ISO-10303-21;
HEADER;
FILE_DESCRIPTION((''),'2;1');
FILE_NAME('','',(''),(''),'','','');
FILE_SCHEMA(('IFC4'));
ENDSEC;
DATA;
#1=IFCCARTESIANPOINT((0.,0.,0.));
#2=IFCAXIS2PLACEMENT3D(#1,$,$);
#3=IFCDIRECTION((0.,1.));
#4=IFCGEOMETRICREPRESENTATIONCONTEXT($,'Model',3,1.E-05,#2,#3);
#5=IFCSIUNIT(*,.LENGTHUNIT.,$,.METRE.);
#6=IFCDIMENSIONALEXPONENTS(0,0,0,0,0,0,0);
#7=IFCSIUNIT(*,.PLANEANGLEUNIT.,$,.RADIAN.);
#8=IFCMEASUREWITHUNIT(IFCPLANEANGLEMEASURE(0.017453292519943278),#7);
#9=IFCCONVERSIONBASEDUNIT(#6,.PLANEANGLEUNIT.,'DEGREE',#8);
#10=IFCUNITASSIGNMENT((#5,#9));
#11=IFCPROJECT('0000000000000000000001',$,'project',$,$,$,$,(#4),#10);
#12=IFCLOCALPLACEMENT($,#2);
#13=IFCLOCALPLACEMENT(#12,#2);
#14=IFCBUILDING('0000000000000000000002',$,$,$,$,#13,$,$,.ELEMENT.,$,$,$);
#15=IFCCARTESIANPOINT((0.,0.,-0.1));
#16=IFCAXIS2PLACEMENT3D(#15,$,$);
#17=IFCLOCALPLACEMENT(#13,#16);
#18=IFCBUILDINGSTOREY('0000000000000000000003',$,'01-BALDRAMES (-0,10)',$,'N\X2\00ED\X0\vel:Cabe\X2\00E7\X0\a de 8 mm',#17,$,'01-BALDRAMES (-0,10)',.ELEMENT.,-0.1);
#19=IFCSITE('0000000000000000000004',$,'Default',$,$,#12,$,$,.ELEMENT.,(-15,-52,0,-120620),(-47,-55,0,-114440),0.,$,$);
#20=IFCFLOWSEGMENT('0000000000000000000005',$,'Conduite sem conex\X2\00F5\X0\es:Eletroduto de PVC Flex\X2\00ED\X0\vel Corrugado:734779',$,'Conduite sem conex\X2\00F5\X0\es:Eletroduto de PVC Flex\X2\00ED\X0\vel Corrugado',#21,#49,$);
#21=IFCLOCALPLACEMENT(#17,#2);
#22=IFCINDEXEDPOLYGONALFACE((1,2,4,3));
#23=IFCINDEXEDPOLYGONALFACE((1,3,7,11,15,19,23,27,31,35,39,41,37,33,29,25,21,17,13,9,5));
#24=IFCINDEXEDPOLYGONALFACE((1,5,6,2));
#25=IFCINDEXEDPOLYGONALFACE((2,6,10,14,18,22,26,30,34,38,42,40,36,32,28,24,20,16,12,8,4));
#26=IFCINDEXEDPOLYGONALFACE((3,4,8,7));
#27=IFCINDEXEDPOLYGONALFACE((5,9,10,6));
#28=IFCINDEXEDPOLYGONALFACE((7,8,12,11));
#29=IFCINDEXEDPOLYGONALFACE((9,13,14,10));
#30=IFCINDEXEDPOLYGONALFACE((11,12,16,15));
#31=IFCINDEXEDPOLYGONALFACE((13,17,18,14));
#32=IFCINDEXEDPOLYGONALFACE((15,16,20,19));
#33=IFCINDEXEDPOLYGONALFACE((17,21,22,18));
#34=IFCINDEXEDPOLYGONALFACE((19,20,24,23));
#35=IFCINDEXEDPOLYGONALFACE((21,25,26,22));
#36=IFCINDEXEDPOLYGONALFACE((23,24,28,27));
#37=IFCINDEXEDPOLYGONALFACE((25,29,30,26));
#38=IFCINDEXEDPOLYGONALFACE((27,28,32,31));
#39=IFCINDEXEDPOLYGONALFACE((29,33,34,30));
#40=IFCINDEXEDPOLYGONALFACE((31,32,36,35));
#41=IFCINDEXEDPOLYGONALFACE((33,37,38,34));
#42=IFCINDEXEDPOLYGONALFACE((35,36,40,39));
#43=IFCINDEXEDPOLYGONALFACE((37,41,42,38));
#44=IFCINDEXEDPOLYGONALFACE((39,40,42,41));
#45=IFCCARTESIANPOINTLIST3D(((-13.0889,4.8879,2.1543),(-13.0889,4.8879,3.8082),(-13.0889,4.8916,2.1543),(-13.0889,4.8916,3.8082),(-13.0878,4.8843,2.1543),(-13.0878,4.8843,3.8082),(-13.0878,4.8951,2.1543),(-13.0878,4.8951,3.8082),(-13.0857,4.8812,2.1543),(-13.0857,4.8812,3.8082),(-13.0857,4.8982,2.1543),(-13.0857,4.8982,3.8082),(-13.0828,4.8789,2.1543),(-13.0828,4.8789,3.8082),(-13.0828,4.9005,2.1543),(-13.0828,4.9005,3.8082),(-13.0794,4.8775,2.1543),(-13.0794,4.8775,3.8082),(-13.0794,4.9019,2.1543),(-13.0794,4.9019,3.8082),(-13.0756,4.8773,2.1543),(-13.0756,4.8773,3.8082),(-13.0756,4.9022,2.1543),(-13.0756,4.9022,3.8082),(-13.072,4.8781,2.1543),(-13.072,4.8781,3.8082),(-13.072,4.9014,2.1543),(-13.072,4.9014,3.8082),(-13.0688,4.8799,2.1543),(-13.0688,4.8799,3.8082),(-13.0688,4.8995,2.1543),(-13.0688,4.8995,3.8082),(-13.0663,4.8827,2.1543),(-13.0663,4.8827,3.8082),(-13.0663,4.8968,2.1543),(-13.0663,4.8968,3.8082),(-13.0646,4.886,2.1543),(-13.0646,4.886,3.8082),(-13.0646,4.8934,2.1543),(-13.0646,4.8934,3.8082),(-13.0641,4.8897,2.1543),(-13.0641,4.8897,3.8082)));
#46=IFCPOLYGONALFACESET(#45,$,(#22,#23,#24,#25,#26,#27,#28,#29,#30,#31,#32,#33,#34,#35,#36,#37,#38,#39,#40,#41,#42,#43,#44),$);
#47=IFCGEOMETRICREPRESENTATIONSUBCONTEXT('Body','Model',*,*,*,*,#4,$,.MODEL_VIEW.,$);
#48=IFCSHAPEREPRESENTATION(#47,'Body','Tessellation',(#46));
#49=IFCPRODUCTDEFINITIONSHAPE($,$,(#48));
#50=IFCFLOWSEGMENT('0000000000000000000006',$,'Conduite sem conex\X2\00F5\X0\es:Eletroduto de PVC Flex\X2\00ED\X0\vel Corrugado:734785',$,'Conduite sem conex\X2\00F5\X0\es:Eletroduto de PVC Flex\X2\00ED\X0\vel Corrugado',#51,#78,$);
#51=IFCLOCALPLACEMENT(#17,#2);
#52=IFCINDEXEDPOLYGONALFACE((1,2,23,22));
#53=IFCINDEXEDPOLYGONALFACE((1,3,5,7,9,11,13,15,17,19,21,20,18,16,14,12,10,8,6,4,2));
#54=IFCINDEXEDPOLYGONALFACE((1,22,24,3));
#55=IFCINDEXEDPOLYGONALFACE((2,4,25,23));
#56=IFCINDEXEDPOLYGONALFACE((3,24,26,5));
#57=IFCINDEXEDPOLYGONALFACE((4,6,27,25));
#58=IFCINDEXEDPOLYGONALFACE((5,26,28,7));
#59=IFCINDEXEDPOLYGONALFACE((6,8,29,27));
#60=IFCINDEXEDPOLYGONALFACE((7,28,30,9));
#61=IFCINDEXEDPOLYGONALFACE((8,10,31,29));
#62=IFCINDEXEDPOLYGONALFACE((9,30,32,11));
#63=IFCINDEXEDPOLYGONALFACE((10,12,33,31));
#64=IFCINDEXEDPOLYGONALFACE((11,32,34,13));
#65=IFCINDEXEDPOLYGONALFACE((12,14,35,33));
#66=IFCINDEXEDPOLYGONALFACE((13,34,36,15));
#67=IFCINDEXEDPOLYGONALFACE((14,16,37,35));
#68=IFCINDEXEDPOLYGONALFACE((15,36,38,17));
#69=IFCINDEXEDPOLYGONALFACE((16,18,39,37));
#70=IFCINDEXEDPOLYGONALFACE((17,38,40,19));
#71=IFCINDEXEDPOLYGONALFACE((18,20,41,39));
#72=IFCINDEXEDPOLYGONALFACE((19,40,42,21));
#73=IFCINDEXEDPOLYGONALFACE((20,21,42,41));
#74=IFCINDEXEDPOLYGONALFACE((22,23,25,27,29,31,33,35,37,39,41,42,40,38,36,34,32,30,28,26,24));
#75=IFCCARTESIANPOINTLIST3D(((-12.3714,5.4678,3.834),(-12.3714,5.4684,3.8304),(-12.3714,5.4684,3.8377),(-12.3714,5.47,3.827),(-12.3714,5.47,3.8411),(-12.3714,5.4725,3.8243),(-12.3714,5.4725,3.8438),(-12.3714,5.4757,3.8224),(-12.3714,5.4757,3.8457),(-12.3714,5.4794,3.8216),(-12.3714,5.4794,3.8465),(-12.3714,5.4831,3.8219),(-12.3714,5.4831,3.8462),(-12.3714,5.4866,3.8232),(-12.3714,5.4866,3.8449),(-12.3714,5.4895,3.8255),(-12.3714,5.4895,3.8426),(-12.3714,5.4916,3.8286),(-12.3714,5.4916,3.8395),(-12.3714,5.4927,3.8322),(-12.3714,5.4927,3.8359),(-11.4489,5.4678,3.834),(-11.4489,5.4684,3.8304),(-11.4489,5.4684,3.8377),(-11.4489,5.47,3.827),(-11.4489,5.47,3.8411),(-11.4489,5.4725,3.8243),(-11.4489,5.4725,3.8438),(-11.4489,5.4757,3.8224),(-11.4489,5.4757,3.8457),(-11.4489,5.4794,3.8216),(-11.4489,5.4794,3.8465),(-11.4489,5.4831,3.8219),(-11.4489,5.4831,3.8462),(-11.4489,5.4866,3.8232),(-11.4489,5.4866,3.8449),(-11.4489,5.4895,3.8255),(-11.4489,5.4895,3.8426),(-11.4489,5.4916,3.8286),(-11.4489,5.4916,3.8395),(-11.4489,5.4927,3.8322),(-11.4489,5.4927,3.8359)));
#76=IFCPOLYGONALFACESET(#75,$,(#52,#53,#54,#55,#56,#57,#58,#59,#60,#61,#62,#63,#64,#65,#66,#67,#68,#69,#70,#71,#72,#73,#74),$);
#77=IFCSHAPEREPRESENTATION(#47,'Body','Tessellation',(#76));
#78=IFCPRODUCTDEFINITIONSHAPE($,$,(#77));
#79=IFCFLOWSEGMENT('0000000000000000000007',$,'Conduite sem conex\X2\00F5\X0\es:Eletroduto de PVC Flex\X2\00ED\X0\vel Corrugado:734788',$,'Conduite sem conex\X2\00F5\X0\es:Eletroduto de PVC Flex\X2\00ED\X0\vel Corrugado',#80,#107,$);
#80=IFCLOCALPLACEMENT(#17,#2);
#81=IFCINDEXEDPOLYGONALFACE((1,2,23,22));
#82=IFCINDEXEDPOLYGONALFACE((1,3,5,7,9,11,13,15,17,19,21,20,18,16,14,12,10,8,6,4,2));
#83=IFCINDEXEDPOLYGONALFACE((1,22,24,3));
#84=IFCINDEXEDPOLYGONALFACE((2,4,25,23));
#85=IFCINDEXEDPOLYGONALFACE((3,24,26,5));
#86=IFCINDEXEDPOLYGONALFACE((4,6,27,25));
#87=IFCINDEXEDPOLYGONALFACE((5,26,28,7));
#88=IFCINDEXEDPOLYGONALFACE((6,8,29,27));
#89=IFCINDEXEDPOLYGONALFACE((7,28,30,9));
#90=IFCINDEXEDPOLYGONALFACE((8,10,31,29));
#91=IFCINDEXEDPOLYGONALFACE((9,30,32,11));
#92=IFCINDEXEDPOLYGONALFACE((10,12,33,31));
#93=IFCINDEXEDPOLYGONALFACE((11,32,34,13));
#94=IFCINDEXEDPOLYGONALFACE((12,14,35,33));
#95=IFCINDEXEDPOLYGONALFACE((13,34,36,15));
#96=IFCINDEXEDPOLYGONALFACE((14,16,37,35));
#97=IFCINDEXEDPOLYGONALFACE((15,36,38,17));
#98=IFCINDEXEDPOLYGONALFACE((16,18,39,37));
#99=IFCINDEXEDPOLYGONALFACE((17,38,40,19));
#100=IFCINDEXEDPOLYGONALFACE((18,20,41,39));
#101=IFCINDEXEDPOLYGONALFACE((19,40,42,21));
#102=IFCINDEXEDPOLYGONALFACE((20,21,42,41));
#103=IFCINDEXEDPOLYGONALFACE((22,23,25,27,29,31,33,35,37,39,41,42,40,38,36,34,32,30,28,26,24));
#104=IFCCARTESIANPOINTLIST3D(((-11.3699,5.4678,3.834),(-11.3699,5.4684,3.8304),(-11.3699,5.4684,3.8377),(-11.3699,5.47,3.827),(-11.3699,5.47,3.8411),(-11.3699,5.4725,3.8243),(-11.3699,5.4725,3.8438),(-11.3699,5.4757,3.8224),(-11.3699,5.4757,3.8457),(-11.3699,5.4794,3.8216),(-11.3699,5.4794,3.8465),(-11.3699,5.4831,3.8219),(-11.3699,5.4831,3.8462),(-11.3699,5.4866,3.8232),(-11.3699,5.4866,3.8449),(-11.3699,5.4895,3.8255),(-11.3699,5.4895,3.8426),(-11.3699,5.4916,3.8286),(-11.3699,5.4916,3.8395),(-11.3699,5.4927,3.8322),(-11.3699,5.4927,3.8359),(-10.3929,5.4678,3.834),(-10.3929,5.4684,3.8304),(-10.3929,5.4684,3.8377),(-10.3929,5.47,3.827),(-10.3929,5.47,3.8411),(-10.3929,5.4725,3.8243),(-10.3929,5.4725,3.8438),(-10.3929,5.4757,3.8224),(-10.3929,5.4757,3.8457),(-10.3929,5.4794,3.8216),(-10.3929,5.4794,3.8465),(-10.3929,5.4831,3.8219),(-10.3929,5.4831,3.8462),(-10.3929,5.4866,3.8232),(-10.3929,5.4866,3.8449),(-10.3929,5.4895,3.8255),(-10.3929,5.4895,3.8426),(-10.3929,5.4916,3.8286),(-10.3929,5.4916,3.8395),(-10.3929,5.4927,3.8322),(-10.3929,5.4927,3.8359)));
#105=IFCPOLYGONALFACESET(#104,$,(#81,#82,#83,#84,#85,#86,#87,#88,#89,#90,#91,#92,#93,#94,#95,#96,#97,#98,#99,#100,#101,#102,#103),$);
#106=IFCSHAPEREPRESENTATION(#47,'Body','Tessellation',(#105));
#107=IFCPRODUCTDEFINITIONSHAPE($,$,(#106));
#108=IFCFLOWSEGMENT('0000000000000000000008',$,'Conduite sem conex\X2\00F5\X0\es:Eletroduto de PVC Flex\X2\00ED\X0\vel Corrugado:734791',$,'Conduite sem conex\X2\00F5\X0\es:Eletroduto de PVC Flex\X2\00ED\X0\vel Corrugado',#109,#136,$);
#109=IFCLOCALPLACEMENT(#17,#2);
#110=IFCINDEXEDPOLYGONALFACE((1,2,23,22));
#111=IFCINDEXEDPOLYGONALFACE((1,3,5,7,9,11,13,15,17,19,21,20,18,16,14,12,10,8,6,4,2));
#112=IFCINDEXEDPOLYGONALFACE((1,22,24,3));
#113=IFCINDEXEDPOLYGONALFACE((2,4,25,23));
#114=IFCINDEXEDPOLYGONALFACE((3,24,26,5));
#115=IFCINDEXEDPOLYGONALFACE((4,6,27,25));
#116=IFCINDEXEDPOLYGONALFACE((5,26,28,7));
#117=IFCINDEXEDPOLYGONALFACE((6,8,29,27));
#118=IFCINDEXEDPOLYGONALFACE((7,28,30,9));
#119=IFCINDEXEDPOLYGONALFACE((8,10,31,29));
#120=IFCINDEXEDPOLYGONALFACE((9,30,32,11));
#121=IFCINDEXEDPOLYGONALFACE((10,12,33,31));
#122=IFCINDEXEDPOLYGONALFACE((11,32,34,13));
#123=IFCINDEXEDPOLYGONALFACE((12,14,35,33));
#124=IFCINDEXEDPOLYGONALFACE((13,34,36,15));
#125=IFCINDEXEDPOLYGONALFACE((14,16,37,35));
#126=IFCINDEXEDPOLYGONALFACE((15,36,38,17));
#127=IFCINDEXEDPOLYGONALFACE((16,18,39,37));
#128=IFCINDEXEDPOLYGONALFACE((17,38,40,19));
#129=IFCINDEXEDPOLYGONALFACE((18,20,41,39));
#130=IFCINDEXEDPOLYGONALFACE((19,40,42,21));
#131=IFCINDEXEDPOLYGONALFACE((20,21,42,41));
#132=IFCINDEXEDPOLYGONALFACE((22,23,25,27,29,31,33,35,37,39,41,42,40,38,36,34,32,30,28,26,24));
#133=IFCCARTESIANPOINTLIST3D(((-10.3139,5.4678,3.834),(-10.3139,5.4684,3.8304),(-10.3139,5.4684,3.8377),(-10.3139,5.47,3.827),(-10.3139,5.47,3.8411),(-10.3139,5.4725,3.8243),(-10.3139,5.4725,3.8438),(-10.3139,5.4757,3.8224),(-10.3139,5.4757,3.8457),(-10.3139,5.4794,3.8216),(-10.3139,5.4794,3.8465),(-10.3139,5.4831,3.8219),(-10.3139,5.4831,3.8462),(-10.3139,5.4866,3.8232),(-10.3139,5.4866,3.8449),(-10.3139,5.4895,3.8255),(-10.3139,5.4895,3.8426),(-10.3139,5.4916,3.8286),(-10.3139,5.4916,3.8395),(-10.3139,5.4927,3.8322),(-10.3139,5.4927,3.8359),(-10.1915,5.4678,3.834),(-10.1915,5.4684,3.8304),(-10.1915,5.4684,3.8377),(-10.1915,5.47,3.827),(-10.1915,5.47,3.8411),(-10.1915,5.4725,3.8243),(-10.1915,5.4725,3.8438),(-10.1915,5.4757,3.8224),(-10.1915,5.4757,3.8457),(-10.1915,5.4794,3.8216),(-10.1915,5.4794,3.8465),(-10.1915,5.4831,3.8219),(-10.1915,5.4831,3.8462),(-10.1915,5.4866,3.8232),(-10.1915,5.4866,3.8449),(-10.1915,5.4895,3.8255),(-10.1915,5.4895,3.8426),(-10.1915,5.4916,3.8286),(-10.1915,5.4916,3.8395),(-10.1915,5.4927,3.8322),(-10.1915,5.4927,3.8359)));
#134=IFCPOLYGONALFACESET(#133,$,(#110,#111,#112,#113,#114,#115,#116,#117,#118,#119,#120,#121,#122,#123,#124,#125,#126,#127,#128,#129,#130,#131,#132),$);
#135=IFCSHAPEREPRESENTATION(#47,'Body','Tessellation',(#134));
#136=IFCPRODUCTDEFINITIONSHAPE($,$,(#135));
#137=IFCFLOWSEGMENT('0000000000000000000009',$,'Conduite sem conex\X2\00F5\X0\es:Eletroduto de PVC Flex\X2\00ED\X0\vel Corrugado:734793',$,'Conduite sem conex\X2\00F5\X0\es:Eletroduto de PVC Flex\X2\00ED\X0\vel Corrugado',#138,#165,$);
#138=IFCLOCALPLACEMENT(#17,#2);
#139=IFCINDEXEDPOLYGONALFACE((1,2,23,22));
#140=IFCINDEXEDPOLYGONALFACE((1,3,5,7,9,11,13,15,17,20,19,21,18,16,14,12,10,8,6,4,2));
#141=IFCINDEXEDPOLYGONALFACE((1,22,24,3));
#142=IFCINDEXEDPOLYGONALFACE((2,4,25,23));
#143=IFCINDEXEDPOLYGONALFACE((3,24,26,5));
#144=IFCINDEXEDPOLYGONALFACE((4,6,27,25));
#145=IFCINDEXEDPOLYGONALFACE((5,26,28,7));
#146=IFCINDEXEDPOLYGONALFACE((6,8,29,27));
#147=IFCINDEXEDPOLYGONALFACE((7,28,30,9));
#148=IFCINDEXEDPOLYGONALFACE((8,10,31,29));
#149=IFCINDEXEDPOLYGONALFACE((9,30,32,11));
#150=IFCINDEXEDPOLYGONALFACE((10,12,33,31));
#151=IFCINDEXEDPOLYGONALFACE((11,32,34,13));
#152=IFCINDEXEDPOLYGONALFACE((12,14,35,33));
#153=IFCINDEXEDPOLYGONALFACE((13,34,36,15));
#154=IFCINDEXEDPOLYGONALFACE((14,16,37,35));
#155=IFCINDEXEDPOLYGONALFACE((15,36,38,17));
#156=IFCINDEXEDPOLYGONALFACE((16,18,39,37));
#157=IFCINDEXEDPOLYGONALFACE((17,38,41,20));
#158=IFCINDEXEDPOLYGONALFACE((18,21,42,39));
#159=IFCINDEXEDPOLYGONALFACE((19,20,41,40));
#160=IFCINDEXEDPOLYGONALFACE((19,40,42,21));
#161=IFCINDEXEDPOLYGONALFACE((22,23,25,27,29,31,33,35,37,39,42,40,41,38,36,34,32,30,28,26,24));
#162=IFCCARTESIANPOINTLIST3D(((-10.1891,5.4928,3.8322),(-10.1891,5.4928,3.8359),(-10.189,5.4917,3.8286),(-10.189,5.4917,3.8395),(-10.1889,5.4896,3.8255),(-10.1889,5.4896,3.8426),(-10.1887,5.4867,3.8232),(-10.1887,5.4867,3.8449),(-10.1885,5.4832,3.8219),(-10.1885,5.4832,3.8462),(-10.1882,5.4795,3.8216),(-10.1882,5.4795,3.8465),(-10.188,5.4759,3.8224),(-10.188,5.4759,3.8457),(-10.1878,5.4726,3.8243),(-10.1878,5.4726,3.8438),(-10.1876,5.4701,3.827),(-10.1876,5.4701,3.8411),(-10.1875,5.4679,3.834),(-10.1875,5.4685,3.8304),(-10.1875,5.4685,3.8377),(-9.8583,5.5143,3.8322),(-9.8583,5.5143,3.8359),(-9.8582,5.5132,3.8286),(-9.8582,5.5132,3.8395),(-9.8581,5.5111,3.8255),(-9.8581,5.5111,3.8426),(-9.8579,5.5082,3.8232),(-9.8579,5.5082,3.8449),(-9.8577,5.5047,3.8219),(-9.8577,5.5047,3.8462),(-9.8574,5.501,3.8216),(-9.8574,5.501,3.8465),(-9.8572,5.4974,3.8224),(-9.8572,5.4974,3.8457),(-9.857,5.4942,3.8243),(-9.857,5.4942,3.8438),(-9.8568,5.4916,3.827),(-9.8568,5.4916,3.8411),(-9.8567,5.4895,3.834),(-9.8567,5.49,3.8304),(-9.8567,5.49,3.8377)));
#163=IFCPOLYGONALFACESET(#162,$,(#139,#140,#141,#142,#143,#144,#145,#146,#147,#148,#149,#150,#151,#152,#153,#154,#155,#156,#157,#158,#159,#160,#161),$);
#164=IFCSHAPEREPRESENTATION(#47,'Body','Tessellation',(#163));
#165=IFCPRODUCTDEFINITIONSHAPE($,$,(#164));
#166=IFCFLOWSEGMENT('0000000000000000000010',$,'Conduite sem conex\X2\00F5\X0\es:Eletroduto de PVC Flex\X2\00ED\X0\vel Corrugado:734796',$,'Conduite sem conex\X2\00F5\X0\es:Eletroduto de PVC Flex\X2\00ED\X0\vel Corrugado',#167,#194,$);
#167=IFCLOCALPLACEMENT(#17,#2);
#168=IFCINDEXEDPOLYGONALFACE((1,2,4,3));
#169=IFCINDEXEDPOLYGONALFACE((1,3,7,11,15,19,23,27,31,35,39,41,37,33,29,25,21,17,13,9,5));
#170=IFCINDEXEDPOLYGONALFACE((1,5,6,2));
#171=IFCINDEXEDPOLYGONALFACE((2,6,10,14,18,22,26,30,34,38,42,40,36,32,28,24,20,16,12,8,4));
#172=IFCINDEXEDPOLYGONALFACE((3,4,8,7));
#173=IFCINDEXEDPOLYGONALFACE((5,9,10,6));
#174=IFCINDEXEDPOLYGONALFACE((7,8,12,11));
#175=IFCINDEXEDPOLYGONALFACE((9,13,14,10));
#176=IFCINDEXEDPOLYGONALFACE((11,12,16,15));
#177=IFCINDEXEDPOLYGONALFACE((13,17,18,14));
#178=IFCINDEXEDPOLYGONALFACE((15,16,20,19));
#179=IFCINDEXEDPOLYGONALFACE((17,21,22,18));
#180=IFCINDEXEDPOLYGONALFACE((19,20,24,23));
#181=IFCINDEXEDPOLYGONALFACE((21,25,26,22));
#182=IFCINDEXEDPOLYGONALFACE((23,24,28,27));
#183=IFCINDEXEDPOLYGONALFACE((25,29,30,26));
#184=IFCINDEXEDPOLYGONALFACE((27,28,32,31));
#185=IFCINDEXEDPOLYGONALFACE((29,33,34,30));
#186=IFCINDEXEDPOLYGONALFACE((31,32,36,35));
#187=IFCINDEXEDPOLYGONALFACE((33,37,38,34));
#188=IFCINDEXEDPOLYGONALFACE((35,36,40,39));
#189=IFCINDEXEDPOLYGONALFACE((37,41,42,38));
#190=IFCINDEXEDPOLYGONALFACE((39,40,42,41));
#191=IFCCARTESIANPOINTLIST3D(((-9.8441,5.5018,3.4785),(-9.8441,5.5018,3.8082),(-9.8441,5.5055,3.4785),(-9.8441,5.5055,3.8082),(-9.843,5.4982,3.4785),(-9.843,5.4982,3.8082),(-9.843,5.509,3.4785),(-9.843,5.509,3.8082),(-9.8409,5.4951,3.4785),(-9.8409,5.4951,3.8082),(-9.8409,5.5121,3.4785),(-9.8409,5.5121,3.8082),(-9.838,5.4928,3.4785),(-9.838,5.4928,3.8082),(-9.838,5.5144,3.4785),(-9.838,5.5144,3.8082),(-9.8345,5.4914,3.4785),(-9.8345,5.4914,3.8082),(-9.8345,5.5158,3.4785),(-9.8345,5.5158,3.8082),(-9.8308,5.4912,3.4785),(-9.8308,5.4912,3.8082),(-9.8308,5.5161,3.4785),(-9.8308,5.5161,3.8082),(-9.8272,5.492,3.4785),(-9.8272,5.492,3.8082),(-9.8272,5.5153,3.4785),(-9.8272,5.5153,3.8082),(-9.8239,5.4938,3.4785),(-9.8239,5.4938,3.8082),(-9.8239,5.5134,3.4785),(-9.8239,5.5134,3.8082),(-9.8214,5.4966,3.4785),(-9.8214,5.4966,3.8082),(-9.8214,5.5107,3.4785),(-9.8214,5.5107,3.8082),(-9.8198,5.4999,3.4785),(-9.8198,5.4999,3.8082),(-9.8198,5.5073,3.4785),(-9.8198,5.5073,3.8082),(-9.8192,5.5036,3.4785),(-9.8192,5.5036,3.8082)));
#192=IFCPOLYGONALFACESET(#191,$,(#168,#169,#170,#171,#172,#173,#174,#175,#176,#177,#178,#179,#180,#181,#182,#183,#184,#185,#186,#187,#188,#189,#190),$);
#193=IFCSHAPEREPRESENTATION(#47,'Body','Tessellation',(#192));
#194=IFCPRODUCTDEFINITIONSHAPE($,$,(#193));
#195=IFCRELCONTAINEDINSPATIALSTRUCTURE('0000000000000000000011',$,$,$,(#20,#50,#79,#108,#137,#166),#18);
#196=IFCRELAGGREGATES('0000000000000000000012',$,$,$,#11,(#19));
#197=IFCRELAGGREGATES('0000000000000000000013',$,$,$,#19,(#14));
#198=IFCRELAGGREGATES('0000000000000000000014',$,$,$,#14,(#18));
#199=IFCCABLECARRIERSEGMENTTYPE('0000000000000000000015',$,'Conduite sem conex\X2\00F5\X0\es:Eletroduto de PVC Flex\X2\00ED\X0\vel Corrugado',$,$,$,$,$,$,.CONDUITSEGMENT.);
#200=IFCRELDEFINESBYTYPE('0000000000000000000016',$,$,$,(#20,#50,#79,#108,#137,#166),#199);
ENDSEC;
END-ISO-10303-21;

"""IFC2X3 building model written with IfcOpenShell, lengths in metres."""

from ifc_helpers import new_model, entity, si_unit, converted_unit, direction, frame, origin, origin_2d_with_axis, place, context, subcontext, project, spatial, circle, extrude, type_object, element, save


model = new_model("IFC2X3")

# Units and contexts
model_context = context("Model", 3, precision=1e-05, world=origin(), true_north=direction((0.0, 1.0)))
body_context = subcontext(model_context, "Body", "Model", "MODEL_VIEW")
ifc_project = project(units=[si_unit("LENGTHUNIT", "METRE"), converted_unit("PLANEANGLEUNIT", "DEGREE", entity("IfcPlaneAngleMeasure", 0.017453292519943278), si_unit("PLANEANGLEUNIT", "RADIAN"), dimensions=[0, 0, 0, 0, 0, 0, 0])], contexts=[model_context])

# Site, building, storey
site_placement = place(None, origin())
site = spatial("IfcSite", under=ifc_project, at=site_placement, Name="Default", CompositionType="ELEMENT", RefLatitude=(-15, -52, 0, -120620), RefLongitude=(-47, -55, 0, -114440), RefElevation=0.0)
building_placement = place(site_placement, origin())
building = spatial("IfcBuilding", under=site, at=building_placement, CompositionType="ELEMENT")
storey_placement = place(building_placement, frame((0.0, 0.0, -0.1)))
storey = spatial("IfcBuildingStorey", under=building, at=storey_placement, Name="01-BALDRAMES (-0,10)", ObjectType="Nível:Cabeça de 8 mm", LongName="01-BALDRAMES (-0,10)", CompositionType="ELEMENT", Elevation=-0.1)

# Flow segments
cable_carrier_segment_type = type_object("IfcCableCarrierSegmentType", Name="Conduite sem conexões:Eletroduto de PVC Flexível Corrugado", PredefinedType="CONDUITSEGMENT")
flow_segment_1_placement = place(storey_placement, origin())
element("IfcFlowSegment", 1, at=flow_segment_1_placement, inside=storey, type_object=cable_carrier_segment_type, Name="Conduite sem conexões:Eletroduto de PVC Flexível Corrugado:734779", ObjectType="Conduite sem conexões:Eletroduto de PVC Flexível Corrugado", context=body_context, shape_type="SweptSolid", body=[
    extrude(circle(Radius=0.0125, at=origin_2d_with_axis()), frame((-13.0766, 4.8897, 2.1543)), (0.0, 0.0, 1.0), 1.654),
])
flow_segment_2_placement = place(storey_placement, origin())
element("IfcFlowSegment", 2, at=flow_segment_2_placement, inside=storey, type_object=cable_carrier_segment_type, Name="Conduite sem conexões:Eletroduto de PVC Flexível Corrugado:734785", ObjectType="Conduite sem conexões:Eletroduto de PVC Flexível Corrugado", context=body_context, shape_type="SweptSolid", body=[
    extrude(circle(Radius=0.0125, at=origin_2d_with_axis()), frame((-12.3714, 5.4803, 3.834), z_axis=(1.0, 0.0, 0.0), x_axis=(0.0, -1.0, 0.0)), (0.0, 0.0, 1.0), 0.9225),
])
flow_segment_3_placement = place(storey_placement, origin())
element("IfcFlowSegment", 3, at=flow_segment_3_placement, inside=storey, type_object=cable_carrier_segment_type, Name="Conduite sem conexões:Eletroduto de PVC Flexível Corrugado:734788", ObjectType="Conduite sem conexões:Eletroduto de PVC Flexível Corrugado", context=body_context, shape_type="SweptSolid", body=[
    extrude(circle(Radius=0.0125, at=origin_2d_with_axis()), frame((-11.3699, 5.4803, 3.834), z_axis=(1.0, 0.0, 0.0), x_axis=(0.0, -1.0, 0.0)), (0.0, 0.0, 1.0), 0.977),
])
flow_segment_4_placement = place(storey_placement, origin())
element("IfcFlowSegment", 4, at=flow_segment_4_placement, inside=storey, type_object=cable_carrier_segment_type, Name="Conduite sem conexões:Eletroduto de PVC Flexível Corrugado:734791", ObjectType="Conduite sem conexões:Eletroduto de PVC Flexível Corrugado", context=body_context, shape_type="SweptSolid", body=[
    extrude(circle(Radius=0.0125, at=origin_2d_with_axis()), frame((-10.3139, 5.4803, 3.834), z_axis=(1.0, 0.0, 0.0), x_axis=(0.0, -1.0, 0.0)), (0.0, 0.0, 1.0), 0.1224),
])
flow_segment_5_placement = place(storey_placement, origin())
element("IfcFlowSegment", 5, at=flow_segment_5_placement, inside=storey, type_object=cable_carrier_segment_type, Name="Conduite sem conexões:Eletroduto de PVC Flexível Corrugado:734793", ObjectType="Conduite sem conexões:Eletroduto de PVC Flexível Corrugado", context=body_context, shape_type="SweptSolid", body=[
    extrude(circle(Radius=0.0125, at=origin_2d_with_axis()), frame((-10.1883, 5.4804, 3.834), z_axis=(0.99789, 0.064922, 0.0), x_axis=(0.064922, -0.99789, 0.0)), (0.0, 0.0, 1.0), 0.3315),
])
flow_segment_6_placement = place(storey_placement, origin())
element("IfcFlowSegment", 6, at=flow_segment_6_placement, inside=storey, type_object=cable_carrier_segment_type, Name="Conduite sem conexões:Eletroduto de PVC Flexível Corrugado:734796", ObjectType="Conduite sem conexões:Eletroduto de PVC Flexível Corrugado", context=body_context, shape_type="SweptSolid", body=[
    extrude(circle(Radius=0.0125, at=origin_2d_with_axis()), frame((-9.8317, 5.5036, 3.4785)), (0.0, 0.0, 1.0), 0.3297),
])

save(model, "model.ifc")
